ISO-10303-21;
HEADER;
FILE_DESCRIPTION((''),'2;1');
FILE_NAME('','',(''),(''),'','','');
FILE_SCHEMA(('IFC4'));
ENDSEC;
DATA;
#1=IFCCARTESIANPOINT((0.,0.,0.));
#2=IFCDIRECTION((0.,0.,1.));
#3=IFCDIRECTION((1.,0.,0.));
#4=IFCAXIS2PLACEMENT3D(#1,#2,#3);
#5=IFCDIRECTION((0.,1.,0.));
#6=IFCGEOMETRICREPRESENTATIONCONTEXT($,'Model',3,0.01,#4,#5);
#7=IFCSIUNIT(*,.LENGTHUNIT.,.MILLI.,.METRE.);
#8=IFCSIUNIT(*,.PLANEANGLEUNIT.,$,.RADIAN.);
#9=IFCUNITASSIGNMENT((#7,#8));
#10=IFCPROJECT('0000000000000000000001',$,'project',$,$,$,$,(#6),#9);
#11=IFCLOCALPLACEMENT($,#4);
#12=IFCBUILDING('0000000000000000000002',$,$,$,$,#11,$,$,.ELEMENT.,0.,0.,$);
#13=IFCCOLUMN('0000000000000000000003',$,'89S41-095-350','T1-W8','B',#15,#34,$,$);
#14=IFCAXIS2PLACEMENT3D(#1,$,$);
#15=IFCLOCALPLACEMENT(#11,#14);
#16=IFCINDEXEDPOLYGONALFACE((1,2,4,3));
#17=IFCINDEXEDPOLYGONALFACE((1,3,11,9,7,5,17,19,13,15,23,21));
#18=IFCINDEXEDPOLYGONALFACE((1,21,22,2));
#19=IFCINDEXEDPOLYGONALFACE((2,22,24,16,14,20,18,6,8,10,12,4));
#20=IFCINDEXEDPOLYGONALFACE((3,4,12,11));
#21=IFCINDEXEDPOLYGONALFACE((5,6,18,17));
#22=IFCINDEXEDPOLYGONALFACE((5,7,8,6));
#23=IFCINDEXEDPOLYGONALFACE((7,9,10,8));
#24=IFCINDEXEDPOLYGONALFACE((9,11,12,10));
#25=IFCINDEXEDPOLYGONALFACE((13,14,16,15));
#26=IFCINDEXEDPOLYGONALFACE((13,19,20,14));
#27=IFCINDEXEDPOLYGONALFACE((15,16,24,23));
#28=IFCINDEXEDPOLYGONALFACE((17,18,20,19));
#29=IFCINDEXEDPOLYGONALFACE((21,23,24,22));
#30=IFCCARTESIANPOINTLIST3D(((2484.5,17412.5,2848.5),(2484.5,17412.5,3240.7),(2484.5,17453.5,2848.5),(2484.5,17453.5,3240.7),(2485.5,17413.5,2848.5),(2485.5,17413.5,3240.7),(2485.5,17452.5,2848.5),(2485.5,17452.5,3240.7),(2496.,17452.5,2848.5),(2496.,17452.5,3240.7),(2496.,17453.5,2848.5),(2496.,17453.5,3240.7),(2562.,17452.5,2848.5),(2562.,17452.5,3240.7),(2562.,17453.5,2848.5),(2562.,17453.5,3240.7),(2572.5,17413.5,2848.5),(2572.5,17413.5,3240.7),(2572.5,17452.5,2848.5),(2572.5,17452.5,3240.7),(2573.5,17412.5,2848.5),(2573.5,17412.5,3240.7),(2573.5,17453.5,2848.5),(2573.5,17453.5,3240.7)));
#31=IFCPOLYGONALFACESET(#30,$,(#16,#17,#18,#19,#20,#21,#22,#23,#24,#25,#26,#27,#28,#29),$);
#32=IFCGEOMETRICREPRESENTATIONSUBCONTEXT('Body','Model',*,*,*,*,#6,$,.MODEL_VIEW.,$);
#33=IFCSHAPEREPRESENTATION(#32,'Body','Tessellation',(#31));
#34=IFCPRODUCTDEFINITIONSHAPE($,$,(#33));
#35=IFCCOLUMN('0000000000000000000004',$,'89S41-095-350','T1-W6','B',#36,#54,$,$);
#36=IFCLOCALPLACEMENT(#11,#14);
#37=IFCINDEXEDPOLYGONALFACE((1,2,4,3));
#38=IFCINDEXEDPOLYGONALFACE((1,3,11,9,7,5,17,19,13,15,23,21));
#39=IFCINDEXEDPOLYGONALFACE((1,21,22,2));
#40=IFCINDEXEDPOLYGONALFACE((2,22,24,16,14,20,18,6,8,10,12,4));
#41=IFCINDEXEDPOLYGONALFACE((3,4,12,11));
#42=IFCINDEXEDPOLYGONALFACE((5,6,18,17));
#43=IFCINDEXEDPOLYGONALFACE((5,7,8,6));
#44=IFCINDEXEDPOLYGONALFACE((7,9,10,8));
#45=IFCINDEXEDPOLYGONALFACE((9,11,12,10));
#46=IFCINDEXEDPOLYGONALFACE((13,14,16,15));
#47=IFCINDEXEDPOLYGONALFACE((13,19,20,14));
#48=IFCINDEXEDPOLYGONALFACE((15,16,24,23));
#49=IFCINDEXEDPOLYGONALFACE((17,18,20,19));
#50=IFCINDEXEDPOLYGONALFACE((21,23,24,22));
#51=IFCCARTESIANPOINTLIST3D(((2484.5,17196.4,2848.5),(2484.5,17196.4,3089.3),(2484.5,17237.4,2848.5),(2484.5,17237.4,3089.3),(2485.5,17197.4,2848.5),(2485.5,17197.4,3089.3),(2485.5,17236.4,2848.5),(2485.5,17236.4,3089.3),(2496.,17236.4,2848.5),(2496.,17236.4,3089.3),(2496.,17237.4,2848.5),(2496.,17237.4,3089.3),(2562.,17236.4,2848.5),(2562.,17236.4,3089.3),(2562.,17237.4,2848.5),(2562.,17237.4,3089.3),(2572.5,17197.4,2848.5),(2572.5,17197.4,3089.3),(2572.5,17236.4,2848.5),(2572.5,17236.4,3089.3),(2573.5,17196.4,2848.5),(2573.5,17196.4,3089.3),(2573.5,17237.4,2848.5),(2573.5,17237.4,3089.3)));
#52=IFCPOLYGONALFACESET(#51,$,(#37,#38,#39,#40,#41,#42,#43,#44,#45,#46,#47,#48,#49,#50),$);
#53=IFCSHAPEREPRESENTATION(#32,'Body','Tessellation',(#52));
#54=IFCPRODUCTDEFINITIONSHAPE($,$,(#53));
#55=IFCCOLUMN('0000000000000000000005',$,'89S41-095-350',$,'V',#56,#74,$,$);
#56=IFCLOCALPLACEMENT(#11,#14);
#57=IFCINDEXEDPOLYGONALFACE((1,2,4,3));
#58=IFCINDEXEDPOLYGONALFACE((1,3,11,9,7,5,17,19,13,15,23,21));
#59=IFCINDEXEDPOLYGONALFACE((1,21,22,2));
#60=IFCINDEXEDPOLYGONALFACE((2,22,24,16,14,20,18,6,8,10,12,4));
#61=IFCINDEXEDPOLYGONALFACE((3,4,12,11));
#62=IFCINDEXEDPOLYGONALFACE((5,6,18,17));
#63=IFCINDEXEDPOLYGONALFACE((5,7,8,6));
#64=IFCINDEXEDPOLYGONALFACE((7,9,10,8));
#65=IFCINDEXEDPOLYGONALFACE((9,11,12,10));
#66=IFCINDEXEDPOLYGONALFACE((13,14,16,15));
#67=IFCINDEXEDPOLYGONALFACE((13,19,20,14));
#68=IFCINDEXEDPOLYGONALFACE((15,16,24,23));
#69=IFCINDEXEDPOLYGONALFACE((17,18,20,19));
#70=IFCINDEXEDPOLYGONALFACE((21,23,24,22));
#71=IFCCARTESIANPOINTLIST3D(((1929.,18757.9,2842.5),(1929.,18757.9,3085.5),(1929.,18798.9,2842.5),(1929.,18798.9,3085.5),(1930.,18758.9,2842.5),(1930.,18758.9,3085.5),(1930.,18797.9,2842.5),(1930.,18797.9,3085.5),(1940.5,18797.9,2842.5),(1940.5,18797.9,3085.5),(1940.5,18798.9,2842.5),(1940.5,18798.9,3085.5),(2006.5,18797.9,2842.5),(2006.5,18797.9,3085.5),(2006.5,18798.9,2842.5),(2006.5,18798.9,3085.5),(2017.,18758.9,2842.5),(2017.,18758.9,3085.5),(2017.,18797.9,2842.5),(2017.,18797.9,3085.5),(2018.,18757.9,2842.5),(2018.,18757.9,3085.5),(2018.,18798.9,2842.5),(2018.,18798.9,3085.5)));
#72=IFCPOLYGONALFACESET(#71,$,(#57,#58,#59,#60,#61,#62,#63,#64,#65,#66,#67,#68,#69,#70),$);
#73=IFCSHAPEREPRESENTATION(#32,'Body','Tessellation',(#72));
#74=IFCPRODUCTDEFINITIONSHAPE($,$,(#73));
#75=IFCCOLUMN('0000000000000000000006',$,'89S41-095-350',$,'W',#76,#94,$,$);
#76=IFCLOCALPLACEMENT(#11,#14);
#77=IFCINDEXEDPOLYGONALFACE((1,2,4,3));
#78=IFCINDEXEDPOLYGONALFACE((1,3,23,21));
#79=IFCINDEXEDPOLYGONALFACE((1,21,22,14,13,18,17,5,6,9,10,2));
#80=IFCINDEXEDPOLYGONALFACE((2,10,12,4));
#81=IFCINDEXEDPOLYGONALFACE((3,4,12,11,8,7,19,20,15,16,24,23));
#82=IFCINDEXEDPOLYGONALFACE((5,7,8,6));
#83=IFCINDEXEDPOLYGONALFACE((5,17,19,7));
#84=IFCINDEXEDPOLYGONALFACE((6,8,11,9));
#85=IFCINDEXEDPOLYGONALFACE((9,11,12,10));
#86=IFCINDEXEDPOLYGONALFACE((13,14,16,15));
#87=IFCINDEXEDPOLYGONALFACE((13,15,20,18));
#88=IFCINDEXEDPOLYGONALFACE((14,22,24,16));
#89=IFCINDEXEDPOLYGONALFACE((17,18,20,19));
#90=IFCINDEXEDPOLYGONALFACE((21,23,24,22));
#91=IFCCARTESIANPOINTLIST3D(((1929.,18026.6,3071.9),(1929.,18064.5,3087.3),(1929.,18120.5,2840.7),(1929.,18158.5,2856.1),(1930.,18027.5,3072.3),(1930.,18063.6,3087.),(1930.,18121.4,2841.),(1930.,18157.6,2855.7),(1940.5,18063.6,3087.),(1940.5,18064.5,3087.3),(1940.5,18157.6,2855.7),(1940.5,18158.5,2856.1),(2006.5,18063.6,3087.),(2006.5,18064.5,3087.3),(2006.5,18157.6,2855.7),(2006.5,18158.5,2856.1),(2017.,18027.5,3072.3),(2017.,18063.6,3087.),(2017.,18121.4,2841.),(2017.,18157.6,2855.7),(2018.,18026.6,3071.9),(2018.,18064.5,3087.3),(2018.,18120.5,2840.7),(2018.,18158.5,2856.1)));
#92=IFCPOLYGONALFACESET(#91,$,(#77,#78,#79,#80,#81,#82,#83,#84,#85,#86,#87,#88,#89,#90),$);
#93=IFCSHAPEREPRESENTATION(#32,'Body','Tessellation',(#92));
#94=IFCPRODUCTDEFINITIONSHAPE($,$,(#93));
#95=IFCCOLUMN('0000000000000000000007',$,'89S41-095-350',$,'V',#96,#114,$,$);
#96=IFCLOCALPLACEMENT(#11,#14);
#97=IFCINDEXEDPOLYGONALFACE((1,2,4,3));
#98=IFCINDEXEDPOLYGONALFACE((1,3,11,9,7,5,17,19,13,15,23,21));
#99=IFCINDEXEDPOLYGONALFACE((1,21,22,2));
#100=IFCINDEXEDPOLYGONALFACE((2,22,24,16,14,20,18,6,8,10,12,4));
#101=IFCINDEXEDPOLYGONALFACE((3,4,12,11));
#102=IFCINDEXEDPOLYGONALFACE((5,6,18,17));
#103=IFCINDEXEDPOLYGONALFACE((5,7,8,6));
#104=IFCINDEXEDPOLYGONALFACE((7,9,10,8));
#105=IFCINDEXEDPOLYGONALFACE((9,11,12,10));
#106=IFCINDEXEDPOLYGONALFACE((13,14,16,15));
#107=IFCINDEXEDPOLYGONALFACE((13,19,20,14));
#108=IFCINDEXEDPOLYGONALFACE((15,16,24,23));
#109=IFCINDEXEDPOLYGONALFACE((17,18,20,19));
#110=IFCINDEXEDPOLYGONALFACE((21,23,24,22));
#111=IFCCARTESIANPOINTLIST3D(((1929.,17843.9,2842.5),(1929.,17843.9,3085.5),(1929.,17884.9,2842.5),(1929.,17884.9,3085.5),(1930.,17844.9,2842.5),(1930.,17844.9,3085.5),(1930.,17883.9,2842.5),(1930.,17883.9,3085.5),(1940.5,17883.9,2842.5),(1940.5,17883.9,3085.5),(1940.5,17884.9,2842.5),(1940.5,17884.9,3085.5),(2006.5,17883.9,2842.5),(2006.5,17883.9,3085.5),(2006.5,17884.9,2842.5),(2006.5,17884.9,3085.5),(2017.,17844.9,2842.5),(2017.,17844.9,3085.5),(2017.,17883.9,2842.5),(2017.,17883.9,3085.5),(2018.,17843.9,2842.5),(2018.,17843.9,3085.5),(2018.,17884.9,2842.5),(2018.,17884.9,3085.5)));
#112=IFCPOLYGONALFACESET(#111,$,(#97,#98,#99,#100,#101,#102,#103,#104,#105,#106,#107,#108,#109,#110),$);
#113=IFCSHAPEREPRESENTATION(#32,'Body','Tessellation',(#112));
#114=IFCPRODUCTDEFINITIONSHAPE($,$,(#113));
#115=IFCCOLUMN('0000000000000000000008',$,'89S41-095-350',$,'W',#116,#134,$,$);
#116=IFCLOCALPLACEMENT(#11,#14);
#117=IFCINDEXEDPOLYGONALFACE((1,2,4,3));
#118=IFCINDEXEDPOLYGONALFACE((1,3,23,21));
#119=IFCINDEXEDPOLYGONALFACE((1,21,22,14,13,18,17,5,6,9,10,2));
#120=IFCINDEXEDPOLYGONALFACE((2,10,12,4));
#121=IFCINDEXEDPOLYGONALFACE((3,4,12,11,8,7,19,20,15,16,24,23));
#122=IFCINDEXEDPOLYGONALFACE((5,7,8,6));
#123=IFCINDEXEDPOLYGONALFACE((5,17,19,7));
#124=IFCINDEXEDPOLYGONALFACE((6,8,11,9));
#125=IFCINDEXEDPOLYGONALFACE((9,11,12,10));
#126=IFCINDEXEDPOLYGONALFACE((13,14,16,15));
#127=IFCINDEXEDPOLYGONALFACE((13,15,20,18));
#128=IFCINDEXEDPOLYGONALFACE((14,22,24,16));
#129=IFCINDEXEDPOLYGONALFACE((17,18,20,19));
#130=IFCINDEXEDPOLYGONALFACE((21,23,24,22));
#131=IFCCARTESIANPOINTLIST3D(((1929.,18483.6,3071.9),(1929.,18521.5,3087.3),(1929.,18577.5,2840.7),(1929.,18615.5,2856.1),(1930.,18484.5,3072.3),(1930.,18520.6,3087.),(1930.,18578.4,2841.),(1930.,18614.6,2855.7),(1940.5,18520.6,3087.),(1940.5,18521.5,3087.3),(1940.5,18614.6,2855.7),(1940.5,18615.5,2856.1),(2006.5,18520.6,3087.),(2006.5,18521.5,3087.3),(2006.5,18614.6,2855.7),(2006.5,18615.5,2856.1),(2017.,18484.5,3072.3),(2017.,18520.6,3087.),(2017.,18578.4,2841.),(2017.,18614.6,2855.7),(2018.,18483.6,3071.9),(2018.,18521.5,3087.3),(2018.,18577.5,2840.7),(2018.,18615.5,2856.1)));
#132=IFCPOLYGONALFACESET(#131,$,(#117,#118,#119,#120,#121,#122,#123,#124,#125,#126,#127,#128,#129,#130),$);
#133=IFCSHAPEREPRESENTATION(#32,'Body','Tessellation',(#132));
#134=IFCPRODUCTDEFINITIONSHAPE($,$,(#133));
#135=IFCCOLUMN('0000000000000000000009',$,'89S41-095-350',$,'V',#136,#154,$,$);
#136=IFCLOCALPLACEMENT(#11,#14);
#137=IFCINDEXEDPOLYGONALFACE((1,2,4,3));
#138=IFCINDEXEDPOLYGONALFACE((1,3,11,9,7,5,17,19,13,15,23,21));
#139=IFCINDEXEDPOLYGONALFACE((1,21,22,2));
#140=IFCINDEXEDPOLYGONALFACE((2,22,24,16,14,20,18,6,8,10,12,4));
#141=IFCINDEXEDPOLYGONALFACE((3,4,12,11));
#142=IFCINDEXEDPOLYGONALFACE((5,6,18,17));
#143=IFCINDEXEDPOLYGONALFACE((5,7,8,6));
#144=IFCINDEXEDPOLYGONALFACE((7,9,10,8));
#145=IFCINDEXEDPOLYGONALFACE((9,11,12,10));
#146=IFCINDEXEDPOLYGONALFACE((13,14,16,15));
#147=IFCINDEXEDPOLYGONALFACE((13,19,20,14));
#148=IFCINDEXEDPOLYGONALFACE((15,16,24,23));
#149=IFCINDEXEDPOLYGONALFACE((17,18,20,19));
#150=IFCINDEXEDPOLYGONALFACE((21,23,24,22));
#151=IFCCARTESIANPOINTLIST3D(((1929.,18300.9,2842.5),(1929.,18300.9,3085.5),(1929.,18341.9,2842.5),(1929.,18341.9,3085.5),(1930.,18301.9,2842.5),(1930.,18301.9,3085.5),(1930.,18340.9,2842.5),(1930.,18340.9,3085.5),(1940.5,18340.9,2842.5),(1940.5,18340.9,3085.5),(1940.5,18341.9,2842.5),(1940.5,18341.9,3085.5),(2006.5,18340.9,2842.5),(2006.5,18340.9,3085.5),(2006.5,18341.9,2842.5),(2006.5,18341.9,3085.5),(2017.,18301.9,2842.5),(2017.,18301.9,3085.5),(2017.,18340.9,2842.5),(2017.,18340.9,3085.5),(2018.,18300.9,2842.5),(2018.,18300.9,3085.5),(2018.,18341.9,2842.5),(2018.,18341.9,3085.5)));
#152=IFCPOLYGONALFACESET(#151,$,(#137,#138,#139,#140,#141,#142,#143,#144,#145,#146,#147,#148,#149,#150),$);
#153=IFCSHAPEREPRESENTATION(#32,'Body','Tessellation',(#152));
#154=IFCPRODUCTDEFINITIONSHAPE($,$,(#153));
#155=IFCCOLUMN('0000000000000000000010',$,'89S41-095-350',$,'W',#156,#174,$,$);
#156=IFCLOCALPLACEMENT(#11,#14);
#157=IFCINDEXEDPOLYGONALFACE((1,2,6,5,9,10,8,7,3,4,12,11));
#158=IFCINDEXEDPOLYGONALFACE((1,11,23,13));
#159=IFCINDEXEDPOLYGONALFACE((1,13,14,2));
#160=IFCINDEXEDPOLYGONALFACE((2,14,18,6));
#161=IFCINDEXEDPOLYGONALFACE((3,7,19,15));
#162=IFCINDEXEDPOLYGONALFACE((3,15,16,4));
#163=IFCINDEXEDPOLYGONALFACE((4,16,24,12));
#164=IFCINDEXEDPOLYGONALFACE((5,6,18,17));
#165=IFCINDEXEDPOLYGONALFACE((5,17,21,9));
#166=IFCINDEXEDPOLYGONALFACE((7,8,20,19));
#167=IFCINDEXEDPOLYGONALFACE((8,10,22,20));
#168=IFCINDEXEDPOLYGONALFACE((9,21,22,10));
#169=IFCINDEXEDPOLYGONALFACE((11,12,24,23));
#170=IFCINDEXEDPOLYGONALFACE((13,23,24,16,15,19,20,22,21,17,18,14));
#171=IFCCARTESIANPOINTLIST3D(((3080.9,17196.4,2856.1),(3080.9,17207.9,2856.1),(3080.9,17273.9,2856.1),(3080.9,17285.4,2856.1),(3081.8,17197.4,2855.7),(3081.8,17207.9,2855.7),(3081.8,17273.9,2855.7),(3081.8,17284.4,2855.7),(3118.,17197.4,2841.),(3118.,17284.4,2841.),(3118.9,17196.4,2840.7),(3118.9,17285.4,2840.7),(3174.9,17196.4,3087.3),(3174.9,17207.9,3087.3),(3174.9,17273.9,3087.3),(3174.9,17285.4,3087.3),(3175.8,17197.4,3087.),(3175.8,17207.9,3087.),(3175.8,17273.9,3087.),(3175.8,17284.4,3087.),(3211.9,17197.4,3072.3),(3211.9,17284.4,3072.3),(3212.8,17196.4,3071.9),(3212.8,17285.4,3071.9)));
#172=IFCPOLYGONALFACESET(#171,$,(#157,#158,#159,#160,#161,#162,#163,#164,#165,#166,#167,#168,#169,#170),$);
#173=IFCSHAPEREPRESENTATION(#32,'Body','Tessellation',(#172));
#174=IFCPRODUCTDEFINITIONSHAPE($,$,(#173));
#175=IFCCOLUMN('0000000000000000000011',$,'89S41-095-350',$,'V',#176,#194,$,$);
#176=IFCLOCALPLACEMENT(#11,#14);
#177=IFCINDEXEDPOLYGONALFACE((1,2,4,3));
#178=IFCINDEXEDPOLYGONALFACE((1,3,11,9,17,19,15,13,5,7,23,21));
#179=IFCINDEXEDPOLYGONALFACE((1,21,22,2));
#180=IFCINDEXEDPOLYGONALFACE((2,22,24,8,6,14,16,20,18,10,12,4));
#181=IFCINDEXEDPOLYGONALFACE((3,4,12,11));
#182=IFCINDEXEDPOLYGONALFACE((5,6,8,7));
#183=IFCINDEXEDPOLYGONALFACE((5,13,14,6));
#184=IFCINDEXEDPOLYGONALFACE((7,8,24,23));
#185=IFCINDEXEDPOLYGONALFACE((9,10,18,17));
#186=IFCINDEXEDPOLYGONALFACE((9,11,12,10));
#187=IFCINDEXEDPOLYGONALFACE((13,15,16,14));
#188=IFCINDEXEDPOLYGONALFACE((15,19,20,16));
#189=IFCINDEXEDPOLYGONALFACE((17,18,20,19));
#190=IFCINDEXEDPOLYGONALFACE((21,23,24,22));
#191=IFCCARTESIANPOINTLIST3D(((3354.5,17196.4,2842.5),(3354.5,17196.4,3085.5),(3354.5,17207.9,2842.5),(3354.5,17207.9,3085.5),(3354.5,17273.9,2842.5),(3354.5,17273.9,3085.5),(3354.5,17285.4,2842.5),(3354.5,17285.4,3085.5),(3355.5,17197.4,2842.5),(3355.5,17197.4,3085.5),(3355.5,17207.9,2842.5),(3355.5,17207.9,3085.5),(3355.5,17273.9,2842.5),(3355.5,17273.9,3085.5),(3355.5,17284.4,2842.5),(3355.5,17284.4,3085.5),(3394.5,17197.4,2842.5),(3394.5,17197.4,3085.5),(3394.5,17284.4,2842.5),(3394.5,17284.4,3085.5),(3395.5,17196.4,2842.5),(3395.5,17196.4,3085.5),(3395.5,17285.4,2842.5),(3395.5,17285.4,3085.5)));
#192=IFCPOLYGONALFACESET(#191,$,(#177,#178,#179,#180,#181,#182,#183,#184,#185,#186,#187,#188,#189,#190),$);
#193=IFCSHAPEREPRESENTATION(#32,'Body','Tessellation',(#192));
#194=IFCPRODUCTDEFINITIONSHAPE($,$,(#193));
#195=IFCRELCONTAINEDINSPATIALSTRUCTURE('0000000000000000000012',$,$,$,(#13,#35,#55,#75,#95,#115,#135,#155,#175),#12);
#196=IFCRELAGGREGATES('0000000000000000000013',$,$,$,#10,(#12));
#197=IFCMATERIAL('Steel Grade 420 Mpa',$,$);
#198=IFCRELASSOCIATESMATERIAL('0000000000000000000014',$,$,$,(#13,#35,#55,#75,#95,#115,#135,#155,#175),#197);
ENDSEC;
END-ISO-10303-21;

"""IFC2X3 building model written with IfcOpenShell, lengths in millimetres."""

from ifc_helpers import new_model, si_unit, direction, frame, origin, origin_with_axes, origin_2d_with_axis, place, context, subcontext, project, spatial, c_section, extrude, source, transform, mapped, material, element, save


model = new_model("IFC2X3")

# Units and contexts
model_context = context("Model", 3, precision=0.01, world=origin_with_axes(), true_north=direction((0.0, 1.0, 0.0)))
body_context = subcontext(model_context, "Body", "Model", "MODEL_VIEW")
ifc_project = project(units=[si_unit("LENGTHUNIT", "METRE", prefix="MILLI"), si_unit("PLANEANGLEUNIT", "RADIAN")], contexts=[model_context])

# Building
building_placement = place(None, origin_with_axes())
building = spatial("IfcBuilding", under=ifc_project, at=building_placement, CompositionType="ELEMENT", ElevationOfRefHeight=0.0, ElevationOfTerrain=0.0)

# Columns
ifc_material = material(Name="Steel Grade 420 Mpa")
shared_shape_1 = source(origin(), body_context, "Body", "SweptSolid", [
    extrude(c_section(Depth=89.0, Width=41.0, WallThickness=1.0, Girth=11.5, at=origin_2d_with_axis()), origin_with_axes(), (0.0, 0.0, 1.0), 392.2),
])
column_1_placement = place(None, frame((2529.0, 17433.0, 2848.5), z_axis=(0.0, 0.0, 1.0), x_axis=(0.0, 1.0, 0.0)))
element("IfcColumn", 1, at=column_1_placement, inside=building, material=ifc_material, Name="89S41-095-350", Description="T1-W8", ObjectType="B", context=body_context, shape_type="MappedRepresentation", body=[
    mapped(shared_shape_1, transform((0.0, 0.0, 0.0), scale=1.0)),
])
shared_shape_2 = source(origin(), body_context, "Body", "SweptSolid", [
    extrude(c_section(Depth=89.0, Width=41.0, WallThickness=1.0, Girth=11.5, at=origin_2d_with_axis()), origin_with_axes(), (0.0, 0.0, 1.0), 240.8),
])
column_2_placement = place(None, frame((2529.0, 17216.9, 2848.5), z_axis=(0.0, 0.0, 1.0), x_axis=(0.0, 1.0, 0.0)))
element("IfcColumn", 2, at=column_2_placement, inside=building, material=ifc_material, Name="89S41-095-350", Description="T1-W6", ObjectType="B", context=body_context, shape_type="MappedRepresentation", body=[
    mapped(shared_shape_2, transform((0.0, 0.0, 0.0), scale=1.0)),
])
shared_shape_3 = source(origin(), body_context, "Body", "SweptSolid", [
    extrude(c_section(Depth=89.0, Width=41.0, WallThickness=1.0, Girth=11.5, at=origin_2d_with_axis()), origin_with_axes(), (0.0, 0.0, 1.0), 243.0),
])
column_3_placement = place(None, frame((1973.5, 18778.4, 2842.5), z_axis=(0.0, 0.0, 1.0), x_axis=(0.0, 1.0, 0.0)))
element("IfcColumn", 3, at=column_3_placement, inside=building, material=ifc_material, Name="89S41-095-350", ObjectType="V", context=body_context, shape_type="MappedRepresentation", body=[
    mapped(shared_shape_3, transform((0.0, 0.0, 0.0), scale=1.0)),
])
shared_shape_4 = source(origin(), body_context, "Body", "SweptSolid", [
    extrude(c_section(Depth=89.0, Width=41.0, WallThickness=1.0, Girth=11.5, at=origin_2d_with_axis()), origin_with_axes(), (0.0, 0.0, 1.0), 249.6),
])
column_4_placement = place(None, frame((1973.5, 18139.5, 2848.4), z_axis=(0.0, -0.376416, 0.926451), x_axis=(0.0, 0.926451, 0.376416)))
element("IfcColumn", 4, at=column_4_placement, inside=building, material=ifc_material, Name="89S41-095-350", ObjectType="W", context=body_context, shape_type="MappedRepresentation", body=[
    mapped(shared_shape_4, transform((0.0, 0.0, 0.0), scale=1.0)),
])
shared_shape_5 = source(origin(), body_context, "Body", "SweptSolid", [
    extrude(c_section(Depth=89.0, Width=41.0, WallThickness=1.0, Girth=11.5, at=origin_2d_with_axis()), origin_with_axes(), (0.0, 0.0, 1.0), 243.0),
])
column_5_placement = place(None, frame((1973.5, 17864.4, 2842.5), z_axis=(0.0, 0.0, 1.0), x_axis=(0.0, 1.0, 0.0)))
element("IfcColumn", 5, at=column_5_placement, inside=building, material=ifc_material, Name="89S41-095-350", ObjectType="V", context=body_context, shape_type="MappedRepresentation", body=[
    mapped(shared_shape_5, transform((0.0, 0.0, 0.0), scale=1.0)),
])
shared_shape_6 = source(origin(), body_context, "Body", "SweptSolid", [
    extrude(c_section(Depth=89.0, Width=41.0, WallThickness=1.0, Girth=11.5, at=origin_2d_with_axis()), origin_with_axes(), (0.0, 0.0, 1.0), 249.6),
])
column_6_placement = place(None, frame((1973.5, 18596.5, 2848.4), z_axis=(0.0, -0.376416, 0.926451), x_axis=(0.0, 0.926451, 0.376416)))
element("IfcColumn", 6, at=column_6_placement, inside=building, material=ifc_material, Name="89S41-095-350", ObjectType="W", context=body_context, shape_type="MappedRepresentation", body=[
    mapped(shared_shape_6, transform((0.0, 0.0, 0.0), scale=1.0)),
])
shared_shape_7 = source(origin(), body_context, "Body", "SweptSolid", [
    extrude(c_section(Depth=89.0, Width=41.0, WallThickness=1.0, Girth=11.5, at=origin_2d_with_axis()), origin_with_axes(), (0.0, 0.0, 1.0), 243.0),
])
column_7_placement = place(None, frame((1973.5, 18321.4, 2842.5), z_axis=(0.0, 0.0, 1.0), x_axis=(0.0, 1.0, 0.0)))
element("IfcColumn", 7, at=column_7_placement, inside=building, material=ifc_material, Name="89S41-095-350", ObjectType="V", context=body_context, shape_type="MappedRepresentation", body=[
    mapped(shared_shape_7, transform((0.0, 0.0, 0.0), scale=1.0)),
])
shared_shape_8 = source(origin(), body_context, "Body", "SweptSolid", [
    extrude(c_section(Depth=89.0, Width=41.0, WallThickness=1.0, Girth=11.5, at=origin_2d_with_axis()), origin_with_axes(), (0.0, 0.0, 1.0), 249.6),
])
column_8_placement = place(None, frame((3099.9, 17240.9, 2848.4), z_axis=(0.376416, 0.0, 0.926451), x_axis=(-0.926451, 0.0, 0.376416)))
element("IfcColumn", 8, at=column_8_placement, inside=building, material=ifc_material, Name="89S41-095-350", ObjectType="W", context=body_context, shape_type="MappedRepresentation", body=[
    mapped(shared_shape_8, transform((0.0, 0.0, 0.0), scale=1.0)),
])
shared_shape_9 = source(origin(), body_context, "Body", "SweptSolid", [
    extrude(c_section(Depth=89.0, Width=41.0, WallThickness=1.0, Girth=11.5, at=origin_2d_with_axis()), origin_with_axes(), (0.0, 0.0, 1.0), 243.0),
])
column_9_placement = place(None, frame((3375.0, 17240.9, 2842.5), z_axis=(0.0, 0.0, 1.0), x_axis=(-1.0, 0.0, 0.0)))
element("IfcColumn", 9, at=column_9_placement, inside=building, material=ifc_material, Name="89S41-095-350", ObjectType="V", context=body_context, shape_type="MappedRepresentation", body=[
    mapped(shared_shape_9, transform((0.0, 0.0, 0.0), scale=1.0)),
])

save(model, "model.ifc")
